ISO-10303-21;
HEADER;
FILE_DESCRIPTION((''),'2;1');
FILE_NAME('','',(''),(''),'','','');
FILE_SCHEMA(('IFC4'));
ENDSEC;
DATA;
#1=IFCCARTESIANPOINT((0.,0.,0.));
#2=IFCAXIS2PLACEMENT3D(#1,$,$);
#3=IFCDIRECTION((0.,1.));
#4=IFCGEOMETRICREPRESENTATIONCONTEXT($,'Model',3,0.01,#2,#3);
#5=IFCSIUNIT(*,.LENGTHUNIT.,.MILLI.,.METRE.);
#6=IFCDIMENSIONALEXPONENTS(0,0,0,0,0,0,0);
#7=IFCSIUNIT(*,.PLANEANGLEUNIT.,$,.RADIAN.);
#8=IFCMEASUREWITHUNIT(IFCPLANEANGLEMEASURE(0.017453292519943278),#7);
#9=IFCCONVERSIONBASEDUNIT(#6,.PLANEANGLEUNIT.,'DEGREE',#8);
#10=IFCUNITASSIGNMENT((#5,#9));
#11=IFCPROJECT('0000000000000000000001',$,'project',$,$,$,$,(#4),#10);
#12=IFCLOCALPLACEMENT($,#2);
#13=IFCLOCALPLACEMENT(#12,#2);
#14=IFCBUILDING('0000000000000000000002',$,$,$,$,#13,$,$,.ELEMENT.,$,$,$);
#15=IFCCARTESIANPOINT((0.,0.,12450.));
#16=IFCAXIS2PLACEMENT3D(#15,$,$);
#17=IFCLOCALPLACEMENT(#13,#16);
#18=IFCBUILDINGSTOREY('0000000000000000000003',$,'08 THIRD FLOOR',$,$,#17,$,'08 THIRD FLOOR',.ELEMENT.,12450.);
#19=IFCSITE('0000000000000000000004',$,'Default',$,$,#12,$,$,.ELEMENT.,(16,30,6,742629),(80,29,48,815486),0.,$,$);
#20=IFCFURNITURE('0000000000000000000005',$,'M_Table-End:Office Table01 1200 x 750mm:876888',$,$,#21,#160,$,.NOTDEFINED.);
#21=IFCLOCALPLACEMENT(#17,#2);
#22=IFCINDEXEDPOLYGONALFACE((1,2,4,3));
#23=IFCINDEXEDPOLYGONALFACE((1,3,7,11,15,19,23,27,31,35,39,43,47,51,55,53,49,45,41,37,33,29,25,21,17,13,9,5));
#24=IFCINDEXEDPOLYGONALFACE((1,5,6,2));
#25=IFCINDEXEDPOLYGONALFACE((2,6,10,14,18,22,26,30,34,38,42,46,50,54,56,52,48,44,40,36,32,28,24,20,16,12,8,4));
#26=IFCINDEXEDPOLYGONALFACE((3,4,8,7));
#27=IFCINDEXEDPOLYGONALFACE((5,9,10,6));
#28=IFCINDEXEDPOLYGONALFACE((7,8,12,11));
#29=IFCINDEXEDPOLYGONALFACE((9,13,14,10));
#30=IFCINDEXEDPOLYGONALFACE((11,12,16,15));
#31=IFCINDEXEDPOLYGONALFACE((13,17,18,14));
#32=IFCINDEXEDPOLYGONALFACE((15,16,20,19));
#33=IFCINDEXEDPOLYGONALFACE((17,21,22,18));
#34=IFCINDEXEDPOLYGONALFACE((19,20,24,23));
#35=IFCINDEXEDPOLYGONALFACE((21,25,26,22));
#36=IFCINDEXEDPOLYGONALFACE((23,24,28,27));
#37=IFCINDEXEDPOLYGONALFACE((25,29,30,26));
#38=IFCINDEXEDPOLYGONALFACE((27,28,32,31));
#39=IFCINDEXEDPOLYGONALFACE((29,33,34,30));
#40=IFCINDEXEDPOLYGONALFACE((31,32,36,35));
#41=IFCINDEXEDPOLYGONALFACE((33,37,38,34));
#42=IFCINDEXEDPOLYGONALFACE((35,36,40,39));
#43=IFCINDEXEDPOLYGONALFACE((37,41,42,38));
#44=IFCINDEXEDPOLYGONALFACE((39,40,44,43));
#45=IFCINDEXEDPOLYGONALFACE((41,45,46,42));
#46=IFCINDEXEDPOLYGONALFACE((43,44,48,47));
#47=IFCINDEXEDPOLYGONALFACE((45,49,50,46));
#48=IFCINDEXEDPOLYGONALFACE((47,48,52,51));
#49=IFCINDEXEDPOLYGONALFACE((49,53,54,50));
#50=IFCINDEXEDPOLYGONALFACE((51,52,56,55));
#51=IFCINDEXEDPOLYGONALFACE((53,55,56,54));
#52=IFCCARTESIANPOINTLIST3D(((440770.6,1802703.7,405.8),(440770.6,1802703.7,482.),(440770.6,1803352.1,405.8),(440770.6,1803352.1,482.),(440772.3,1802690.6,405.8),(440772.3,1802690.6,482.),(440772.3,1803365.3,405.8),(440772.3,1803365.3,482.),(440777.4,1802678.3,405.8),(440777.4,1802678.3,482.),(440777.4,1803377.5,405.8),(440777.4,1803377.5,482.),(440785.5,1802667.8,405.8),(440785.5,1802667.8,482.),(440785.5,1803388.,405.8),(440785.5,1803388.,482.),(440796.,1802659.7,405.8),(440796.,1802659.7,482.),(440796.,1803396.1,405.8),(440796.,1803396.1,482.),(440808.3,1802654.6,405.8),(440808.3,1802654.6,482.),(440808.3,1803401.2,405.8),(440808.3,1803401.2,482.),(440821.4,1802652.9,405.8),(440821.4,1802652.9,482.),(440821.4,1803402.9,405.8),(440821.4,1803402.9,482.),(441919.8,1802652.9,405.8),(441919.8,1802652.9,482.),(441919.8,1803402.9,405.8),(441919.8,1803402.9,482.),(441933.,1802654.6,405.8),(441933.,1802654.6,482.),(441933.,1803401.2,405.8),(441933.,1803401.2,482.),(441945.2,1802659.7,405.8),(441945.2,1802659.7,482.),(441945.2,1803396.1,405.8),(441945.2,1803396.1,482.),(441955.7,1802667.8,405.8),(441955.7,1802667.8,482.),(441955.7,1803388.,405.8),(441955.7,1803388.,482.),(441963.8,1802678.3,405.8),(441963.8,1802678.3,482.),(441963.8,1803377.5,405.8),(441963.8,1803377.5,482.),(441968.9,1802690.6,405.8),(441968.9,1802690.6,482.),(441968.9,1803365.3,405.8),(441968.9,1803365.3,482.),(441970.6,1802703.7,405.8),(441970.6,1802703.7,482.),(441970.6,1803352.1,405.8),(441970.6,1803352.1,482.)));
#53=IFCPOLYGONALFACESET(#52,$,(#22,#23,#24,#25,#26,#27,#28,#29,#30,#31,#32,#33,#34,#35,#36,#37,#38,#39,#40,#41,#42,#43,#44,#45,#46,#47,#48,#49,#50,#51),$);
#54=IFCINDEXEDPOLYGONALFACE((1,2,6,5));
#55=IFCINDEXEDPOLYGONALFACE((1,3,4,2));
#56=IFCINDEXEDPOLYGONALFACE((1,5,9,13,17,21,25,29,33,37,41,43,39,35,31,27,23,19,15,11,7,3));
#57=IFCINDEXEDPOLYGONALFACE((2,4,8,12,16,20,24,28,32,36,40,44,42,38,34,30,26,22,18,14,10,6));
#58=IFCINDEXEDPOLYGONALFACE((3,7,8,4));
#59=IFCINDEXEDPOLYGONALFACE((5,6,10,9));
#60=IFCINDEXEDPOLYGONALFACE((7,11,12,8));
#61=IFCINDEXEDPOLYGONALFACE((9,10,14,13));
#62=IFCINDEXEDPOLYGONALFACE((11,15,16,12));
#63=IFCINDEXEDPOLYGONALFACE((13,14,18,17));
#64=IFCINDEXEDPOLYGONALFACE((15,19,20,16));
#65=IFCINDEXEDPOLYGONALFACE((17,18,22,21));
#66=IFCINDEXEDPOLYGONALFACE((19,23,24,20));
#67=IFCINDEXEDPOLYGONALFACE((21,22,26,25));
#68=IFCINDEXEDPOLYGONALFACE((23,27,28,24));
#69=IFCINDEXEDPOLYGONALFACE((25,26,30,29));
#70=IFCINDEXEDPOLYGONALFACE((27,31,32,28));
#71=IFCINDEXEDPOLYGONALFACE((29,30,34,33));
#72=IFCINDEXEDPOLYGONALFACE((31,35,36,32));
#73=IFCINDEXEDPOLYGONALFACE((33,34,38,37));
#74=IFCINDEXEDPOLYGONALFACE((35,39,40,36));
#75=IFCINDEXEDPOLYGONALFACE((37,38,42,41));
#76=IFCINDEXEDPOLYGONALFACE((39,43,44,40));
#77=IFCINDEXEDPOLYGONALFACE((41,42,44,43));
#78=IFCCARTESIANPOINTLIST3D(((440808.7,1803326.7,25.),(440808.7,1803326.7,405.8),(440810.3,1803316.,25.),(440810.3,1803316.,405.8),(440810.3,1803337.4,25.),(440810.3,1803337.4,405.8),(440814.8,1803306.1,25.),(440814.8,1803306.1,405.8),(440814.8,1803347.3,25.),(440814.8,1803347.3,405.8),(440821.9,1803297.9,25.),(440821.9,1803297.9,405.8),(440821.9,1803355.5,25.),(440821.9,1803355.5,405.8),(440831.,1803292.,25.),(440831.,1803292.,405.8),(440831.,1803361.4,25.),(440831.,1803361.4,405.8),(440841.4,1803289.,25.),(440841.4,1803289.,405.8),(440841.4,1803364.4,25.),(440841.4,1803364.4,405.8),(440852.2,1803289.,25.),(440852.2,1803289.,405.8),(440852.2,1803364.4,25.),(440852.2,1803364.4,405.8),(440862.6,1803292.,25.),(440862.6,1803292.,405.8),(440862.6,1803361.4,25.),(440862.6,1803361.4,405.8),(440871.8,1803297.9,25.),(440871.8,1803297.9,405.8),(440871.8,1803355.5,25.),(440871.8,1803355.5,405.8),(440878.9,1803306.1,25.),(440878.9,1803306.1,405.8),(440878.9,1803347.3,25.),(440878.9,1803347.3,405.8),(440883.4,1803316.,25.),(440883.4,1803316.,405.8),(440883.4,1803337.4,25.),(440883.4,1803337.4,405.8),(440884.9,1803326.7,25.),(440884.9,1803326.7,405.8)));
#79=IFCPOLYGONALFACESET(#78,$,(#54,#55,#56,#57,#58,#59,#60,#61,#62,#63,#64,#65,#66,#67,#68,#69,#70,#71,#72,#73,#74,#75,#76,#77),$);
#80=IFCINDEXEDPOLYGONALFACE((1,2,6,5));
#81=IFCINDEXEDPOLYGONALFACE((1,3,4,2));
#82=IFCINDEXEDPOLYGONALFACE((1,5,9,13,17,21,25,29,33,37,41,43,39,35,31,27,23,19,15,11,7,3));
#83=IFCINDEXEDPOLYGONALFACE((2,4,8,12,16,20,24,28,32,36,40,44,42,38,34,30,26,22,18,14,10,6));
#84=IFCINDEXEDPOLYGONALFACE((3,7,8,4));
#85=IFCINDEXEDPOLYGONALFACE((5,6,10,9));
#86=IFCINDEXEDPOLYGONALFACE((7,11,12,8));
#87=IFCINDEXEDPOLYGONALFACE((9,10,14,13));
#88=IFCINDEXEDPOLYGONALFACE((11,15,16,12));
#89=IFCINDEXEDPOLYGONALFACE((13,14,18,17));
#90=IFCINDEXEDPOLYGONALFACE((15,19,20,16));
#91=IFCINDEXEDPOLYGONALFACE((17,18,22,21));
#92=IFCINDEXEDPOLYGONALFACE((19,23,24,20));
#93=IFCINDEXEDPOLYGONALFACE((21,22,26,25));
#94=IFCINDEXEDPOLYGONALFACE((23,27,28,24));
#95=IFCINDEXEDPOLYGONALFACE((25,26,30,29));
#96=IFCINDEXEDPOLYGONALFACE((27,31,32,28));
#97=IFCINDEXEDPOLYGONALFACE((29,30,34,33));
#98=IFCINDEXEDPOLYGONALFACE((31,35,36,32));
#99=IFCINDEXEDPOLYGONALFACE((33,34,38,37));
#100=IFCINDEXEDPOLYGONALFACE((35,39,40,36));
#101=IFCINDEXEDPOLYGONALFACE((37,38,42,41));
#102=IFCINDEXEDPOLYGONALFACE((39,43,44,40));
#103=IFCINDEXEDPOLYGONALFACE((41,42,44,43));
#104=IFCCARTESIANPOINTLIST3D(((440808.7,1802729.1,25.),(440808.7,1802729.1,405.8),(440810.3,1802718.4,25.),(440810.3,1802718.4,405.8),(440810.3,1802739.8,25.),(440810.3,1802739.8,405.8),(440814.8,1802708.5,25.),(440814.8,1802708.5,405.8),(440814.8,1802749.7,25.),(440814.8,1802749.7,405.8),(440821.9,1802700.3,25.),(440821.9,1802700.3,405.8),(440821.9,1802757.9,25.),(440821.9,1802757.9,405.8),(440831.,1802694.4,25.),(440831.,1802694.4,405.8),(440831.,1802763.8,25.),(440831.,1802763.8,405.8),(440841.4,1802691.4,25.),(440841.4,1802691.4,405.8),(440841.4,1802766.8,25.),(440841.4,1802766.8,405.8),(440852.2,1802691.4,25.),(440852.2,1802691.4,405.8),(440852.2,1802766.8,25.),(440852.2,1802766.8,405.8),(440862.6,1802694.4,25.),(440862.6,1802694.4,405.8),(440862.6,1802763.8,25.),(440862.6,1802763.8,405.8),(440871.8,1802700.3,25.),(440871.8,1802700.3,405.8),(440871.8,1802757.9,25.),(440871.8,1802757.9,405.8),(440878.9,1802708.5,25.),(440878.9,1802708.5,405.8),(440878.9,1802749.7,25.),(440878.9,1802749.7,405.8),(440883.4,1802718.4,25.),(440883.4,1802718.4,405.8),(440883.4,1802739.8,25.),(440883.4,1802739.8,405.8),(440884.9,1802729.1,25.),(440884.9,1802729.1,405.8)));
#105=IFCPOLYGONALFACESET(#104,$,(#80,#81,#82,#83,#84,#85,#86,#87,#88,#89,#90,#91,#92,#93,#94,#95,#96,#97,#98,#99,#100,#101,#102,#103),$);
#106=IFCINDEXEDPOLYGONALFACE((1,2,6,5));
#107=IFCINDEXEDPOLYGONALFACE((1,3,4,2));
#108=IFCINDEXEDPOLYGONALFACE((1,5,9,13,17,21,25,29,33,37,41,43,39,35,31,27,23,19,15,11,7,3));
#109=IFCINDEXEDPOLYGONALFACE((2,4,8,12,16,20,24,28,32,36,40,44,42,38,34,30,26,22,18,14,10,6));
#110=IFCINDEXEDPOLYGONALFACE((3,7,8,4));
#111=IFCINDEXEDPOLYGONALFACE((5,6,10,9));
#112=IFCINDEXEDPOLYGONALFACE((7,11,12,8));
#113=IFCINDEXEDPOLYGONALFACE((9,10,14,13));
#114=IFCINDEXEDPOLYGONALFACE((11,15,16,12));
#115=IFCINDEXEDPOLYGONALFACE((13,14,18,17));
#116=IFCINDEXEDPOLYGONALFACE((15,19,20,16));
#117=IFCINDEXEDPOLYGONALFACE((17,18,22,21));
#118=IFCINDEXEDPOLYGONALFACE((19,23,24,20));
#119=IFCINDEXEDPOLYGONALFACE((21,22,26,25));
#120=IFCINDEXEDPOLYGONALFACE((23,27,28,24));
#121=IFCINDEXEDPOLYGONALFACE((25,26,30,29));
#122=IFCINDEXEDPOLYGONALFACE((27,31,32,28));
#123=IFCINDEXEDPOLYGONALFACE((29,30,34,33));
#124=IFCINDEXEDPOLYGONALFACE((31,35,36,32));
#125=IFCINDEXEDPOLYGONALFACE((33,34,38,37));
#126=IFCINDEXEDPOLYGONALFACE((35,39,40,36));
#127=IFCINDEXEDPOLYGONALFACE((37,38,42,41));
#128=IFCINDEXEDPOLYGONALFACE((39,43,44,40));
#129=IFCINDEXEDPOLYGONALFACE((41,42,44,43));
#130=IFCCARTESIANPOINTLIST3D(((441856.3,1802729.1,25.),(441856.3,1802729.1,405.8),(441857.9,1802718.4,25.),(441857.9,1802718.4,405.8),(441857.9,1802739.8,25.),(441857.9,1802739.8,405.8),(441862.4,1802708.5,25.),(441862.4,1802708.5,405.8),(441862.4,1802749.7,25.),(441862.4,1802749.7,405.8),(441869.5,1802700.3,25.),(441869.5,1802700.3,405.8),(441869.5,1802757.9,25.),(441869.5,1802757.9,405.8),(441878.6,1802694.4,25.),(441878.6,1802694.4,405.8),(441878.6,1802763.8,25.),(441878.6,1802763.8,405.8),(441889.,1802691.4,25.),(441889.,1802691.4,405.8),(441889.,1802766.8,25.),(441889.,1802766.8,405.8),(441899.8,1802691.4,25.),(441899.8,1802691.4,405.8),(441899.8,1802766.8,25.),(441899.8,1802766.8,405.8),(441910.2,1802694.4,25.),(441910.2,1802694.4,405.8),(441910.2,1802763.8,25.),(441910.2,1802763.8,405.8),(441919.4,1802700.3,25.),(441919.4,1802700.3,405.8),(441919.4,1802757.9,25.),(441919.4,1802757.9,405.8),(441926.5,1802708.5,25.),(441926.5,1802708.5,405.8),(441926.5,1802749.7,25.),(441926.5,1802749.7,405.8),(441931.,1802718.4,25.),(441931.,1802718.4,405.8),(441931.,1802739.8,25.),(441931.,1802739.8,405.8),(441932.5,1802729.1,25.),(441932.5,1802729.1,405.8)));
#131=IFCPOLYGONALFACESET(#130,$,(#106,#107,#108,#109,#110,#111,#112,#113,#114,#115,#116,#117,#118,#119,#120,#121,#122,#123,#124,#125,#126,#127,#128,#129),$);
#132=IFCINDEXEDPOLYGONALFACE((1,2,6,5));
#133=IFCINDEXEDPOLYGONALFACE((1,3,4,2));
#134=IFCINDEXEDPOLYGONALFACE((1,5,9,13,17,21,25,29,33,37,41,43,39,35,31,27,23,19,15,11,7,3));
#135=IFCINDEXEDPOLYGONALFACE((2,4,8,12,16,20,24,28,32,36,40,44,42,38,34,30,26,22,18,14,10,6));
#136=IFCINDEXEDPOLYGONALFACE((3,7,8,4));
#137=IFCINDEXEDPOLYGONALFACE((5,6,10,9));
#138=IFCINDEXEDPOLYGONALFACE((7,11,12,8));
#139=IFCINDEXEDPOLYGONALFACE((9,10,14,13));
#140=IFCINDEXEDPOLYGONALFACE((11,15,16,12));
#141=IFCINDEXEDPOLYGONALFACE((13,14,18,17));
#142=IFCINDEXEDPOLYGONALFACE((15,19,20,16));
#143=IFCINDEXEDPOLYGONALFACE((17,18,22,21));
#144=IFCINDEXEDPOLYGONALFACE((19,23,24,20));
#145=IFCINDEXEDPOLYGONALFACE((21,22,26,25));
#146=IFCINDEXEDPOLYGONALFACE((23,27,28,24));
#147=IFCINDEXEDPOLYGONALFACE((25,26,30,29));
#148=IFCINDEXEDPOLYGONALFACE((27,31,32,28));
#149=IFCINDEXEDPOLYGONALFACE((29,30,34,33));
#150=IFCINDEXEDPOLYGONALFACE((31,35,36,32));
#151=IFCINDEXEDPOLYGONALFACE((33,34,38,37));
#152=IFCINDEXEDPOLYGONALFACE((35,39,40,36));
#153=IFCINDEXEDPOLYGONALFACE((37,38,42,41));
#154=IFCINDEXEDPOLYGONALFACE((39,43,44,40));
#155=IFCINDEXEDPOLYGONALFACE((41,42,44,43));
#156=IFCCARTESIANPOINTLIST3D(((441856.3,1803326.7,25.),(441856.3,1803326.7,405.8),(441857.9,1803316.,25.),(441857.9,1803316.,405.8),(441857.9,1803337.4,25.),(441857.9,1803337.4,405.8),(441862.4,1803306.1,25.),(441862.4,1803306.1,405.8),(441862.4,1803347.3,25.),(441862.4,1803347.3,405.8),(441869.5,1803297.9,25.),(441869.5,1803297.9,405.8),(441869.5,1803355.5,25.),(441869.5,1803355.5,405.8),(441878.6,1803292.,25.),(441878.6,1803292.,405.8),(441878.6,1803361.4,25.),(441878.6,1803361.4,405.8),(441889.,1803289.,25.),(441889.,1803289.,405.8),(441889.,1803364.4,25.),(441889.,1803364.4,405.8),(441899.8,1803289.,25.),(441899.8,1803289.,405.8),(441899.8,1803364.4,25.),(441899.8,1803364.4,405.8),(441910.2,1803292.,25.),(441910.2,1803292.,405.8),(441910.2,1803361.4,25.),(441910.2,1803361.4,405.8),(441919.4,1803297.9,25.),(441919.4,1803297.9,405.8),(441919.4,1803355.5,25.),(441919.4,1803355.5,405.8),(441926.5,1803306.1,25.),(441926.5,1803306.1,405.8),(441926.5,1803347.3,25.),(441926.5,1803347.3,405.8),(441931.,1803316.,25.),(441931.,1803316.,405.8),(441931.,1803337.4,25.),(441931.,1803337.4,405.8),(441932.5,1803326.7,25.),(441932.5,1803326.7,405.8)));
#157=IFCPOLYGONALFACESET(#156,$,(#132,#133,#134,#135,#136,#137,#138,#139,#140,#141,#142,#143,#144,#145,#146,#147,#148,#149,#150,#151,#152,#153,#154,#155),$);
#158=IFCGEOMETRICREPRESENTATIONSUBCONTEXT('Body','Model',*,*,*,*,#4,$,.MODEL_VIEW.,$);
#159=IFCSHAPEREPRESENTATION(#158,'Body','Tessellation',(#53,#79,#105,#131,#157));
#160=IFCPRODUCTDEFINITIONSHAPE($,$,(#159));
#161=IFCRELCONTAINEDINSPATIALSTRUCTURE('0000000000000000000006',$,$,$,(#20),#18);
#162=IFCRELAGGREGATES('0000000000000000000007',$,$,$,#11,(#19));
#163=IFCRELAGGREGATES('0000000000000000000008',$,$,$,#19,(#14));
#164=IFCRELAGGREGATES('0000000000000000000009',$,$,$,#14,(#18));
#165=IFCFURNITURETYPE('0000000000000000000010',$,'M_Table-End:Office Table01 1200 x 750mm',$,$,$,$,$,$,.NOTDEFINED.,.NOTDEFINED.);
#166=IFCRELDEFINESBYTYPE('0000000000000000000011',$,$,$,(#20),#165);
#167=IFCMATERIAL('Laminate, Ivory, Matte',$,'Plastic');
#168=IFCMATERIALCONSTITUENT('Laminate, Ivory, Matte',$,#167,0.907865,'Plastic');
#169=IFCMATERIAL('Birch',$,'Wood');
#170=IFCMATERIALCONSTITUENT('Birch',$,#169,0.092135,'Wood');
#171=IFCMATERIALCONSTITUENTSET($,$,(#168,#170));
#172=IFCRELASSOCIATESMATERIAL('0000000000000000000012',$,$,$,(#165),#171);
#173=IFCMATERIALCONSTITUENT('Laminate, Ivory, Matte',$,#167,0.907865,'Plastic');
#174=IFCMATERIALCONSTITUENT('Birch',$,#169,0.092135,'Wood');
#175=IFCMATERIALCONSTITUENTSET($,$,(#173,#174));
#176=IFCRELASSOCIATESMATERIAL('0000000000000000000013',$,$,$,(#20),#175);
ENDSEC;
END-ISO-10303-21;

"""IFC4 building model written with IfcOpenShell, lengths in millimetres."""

from ifc_helpers import new_model, entity, si_unit, converted_unit, direction, frame, origin, place, context, subcontext, project, spatial, line, arc, indexed_curve, outline, extrude, source, transform, mapped, material, constituent, constituent_set, type_object, type_shapes, element, save


model = new_model("IFC4")

# Units and contexts
model_context = context("Model", 3, precision=0.01, world=origin(), true_north=direction((0.0, 1.0)))
body_context = subcontext(model_context, "Body", "Model", "MODEL_VIEW")
ifc_project = project(units=[si_unit("LENGTHUNIT", "METRE", prefix="MILLI"), converted_unit("PLANEANGLEUNIT", "DEGREE", entity("IfcPlaneAngleMeasure", 0.017453292519943278), si_unit("PLANEANGLEUNIT", "RADIAN"), dimensions=[0, 0, 0, 0, 0, 0, 0])], contexts=[model_context])

# Site, building, storey
site_placement = place(None, origin())
site = spatial("IfcSite", under=ifc_project, at=site_placement, Name="Default", CompositionType="ELEMENT", RefLatitude=(16, 30, 6, 742629), RefLongitude=(80, 29, 48, 815486), RefElevation=0.0)
building_placement = place(site_placement, origin())
building = spatial("IfcBuilding", under=site, at=building_placement, CompositionType="ELEMENT")
storey_placement = place(building_placement, frame((0.0, 0.0, 12450.0)))
storey = spatial("IfcBuildingStorey", under=building, at=storey_placement, Name="08 THIRD FLOOR", LongName="08 THIRD FLOOR", CompositionType="ELEMENT", Elevation=12450.0)

# Furniture
ifc_material_1 = material(Name="Laminate, Ivory, Matte", Category="Plastic")
ifc_material_2 = material(Name="Birch", Category="Wood")
ifc_constituent_1 = constituent(ifc_material_1, Name="Laminate, Ivory, Matte", Category="Plastic", fraction=0.907865)
ifc_constituent_2 = constituent(ifc_material_2, Name="Birch", Category="Wood", fraction=0.092135)
ifc_constituent_set_1 = constituent_set(constituents=[ifc_constituent_1, ifc_constituent_2])
furniture_type_1 = type_object("IfcFurnitureType", Name="M_Table-End:Office Table01 1200 x 750mm", AssemblyPlace="NOTDEFINED", PredefinedType="NOTDEFINED", material=ifc_constituent_set_1)
shared_shape_1 = source(origin(), body_context, "Body", "SweptSolid", [
    extrude(outline(indexed_curve([(549.2, -375.0), (585.1, -360.1), (600.0, -324.2), (600.0, 324.2), (585.1, 360.1), (549.2, 375.0), (-549.2, 375.0), (-585.1, 360.1), (-600.0, 324.2), (-600.0, -324.2), (-585.1, -360.1), (-549.2, -375.0)], segments=[arc(1, 2, 3), line(3, 4), arc(4, 5, 6), line(6, 7), arc(7, 8, 9), line(9, 10), arc(10, 11, 12), line(12, 1)], self_intersect=False)), frame((603.7, 152.4, 405.8)), (0.0, 0.0, 1.0), 76.2),
    extrude(outline(indexed_curve([(-38.1, 0.0), (0.0, -38.1), (38.1, 0.0), (0.0, 38.1)], segments=[arc(1, 2, 3), arc(3, 4, 1)], self_intersect=False)), frame((1127.5, -146.4, 25.0)), (0.0, 0.0, 1.0), 380.8),
    extrude(outline(indexed_curve([(-38.1, 0.0), (0.0, -38.1), (38.1, 0.0), (0.0, 38.1)], segments=[arc(1, 2, 3), arc(3, 4, 1)], self_intersect=False)), frame((1127.5, 451.2, 25.0)), (0.0, 0.0, 1.0), 380.8),
    extrude(outline(indexed_curve([(-38.1, 0.0), (0.0, -38.1), (38.1, 0.0), (0.0, 38.1)], segments=[arc(1, 2, 3), arc(3, 4, 1)], self_intersect=False)), frame((79.9, 451.2, 25.0)), (0.0, 0.0, 1.0), 380.8),
    extrude(outline(indexed_curve([(-38.1, 0.0), (0.0, -38.1), (38.1, 0.0), (0.0, 38.1)], segments=[arc(1, 2, 3), arc(3, 4, 1)], self_intersect=False)), frame((79.9, -146.4, 25.0)), (0.0, 0.0, 1.0), 380.8),
])
type_shapes(furniture_type_1, [shared_shape_1])
ifc_constituent_3 = constituent(ifc_material_1, Name="Laminate, Ivory, Matte", Category="Plastic", fraction=0.907865)
ifc_constituent_4 = constituent(ifc_material_2, Name="Birch", Category="Wood", fraction=0.092135)
ifc_constituent_set_2 = constituent_set(constituents=[ifc_constituent_3, ifc_constituent_4])
furniture_1_placement = place(storey_placement, frame((441974.3, 1803180.3, 0.0), z_axis=(0.0, 0.0, 1.0), x_axis=(-1.0, 0.0, 0.0)))
element("IfcFurniture", 1, at=furniture_1_placement, inside=storey, type_object=furniture_type_1, material=ifc_constituent_set_2, Name="M_Table-End:Office Table01 1200 x 750mm:876888", PredefinedType="NOTDEFINED", context=body_context, shape_type="MappedRepresentation", body=[
    mapped(shared_shape_1, transform((0.0, 0.0, 0.0), scale=1.0)),
])

save(model, "model.ifc")
